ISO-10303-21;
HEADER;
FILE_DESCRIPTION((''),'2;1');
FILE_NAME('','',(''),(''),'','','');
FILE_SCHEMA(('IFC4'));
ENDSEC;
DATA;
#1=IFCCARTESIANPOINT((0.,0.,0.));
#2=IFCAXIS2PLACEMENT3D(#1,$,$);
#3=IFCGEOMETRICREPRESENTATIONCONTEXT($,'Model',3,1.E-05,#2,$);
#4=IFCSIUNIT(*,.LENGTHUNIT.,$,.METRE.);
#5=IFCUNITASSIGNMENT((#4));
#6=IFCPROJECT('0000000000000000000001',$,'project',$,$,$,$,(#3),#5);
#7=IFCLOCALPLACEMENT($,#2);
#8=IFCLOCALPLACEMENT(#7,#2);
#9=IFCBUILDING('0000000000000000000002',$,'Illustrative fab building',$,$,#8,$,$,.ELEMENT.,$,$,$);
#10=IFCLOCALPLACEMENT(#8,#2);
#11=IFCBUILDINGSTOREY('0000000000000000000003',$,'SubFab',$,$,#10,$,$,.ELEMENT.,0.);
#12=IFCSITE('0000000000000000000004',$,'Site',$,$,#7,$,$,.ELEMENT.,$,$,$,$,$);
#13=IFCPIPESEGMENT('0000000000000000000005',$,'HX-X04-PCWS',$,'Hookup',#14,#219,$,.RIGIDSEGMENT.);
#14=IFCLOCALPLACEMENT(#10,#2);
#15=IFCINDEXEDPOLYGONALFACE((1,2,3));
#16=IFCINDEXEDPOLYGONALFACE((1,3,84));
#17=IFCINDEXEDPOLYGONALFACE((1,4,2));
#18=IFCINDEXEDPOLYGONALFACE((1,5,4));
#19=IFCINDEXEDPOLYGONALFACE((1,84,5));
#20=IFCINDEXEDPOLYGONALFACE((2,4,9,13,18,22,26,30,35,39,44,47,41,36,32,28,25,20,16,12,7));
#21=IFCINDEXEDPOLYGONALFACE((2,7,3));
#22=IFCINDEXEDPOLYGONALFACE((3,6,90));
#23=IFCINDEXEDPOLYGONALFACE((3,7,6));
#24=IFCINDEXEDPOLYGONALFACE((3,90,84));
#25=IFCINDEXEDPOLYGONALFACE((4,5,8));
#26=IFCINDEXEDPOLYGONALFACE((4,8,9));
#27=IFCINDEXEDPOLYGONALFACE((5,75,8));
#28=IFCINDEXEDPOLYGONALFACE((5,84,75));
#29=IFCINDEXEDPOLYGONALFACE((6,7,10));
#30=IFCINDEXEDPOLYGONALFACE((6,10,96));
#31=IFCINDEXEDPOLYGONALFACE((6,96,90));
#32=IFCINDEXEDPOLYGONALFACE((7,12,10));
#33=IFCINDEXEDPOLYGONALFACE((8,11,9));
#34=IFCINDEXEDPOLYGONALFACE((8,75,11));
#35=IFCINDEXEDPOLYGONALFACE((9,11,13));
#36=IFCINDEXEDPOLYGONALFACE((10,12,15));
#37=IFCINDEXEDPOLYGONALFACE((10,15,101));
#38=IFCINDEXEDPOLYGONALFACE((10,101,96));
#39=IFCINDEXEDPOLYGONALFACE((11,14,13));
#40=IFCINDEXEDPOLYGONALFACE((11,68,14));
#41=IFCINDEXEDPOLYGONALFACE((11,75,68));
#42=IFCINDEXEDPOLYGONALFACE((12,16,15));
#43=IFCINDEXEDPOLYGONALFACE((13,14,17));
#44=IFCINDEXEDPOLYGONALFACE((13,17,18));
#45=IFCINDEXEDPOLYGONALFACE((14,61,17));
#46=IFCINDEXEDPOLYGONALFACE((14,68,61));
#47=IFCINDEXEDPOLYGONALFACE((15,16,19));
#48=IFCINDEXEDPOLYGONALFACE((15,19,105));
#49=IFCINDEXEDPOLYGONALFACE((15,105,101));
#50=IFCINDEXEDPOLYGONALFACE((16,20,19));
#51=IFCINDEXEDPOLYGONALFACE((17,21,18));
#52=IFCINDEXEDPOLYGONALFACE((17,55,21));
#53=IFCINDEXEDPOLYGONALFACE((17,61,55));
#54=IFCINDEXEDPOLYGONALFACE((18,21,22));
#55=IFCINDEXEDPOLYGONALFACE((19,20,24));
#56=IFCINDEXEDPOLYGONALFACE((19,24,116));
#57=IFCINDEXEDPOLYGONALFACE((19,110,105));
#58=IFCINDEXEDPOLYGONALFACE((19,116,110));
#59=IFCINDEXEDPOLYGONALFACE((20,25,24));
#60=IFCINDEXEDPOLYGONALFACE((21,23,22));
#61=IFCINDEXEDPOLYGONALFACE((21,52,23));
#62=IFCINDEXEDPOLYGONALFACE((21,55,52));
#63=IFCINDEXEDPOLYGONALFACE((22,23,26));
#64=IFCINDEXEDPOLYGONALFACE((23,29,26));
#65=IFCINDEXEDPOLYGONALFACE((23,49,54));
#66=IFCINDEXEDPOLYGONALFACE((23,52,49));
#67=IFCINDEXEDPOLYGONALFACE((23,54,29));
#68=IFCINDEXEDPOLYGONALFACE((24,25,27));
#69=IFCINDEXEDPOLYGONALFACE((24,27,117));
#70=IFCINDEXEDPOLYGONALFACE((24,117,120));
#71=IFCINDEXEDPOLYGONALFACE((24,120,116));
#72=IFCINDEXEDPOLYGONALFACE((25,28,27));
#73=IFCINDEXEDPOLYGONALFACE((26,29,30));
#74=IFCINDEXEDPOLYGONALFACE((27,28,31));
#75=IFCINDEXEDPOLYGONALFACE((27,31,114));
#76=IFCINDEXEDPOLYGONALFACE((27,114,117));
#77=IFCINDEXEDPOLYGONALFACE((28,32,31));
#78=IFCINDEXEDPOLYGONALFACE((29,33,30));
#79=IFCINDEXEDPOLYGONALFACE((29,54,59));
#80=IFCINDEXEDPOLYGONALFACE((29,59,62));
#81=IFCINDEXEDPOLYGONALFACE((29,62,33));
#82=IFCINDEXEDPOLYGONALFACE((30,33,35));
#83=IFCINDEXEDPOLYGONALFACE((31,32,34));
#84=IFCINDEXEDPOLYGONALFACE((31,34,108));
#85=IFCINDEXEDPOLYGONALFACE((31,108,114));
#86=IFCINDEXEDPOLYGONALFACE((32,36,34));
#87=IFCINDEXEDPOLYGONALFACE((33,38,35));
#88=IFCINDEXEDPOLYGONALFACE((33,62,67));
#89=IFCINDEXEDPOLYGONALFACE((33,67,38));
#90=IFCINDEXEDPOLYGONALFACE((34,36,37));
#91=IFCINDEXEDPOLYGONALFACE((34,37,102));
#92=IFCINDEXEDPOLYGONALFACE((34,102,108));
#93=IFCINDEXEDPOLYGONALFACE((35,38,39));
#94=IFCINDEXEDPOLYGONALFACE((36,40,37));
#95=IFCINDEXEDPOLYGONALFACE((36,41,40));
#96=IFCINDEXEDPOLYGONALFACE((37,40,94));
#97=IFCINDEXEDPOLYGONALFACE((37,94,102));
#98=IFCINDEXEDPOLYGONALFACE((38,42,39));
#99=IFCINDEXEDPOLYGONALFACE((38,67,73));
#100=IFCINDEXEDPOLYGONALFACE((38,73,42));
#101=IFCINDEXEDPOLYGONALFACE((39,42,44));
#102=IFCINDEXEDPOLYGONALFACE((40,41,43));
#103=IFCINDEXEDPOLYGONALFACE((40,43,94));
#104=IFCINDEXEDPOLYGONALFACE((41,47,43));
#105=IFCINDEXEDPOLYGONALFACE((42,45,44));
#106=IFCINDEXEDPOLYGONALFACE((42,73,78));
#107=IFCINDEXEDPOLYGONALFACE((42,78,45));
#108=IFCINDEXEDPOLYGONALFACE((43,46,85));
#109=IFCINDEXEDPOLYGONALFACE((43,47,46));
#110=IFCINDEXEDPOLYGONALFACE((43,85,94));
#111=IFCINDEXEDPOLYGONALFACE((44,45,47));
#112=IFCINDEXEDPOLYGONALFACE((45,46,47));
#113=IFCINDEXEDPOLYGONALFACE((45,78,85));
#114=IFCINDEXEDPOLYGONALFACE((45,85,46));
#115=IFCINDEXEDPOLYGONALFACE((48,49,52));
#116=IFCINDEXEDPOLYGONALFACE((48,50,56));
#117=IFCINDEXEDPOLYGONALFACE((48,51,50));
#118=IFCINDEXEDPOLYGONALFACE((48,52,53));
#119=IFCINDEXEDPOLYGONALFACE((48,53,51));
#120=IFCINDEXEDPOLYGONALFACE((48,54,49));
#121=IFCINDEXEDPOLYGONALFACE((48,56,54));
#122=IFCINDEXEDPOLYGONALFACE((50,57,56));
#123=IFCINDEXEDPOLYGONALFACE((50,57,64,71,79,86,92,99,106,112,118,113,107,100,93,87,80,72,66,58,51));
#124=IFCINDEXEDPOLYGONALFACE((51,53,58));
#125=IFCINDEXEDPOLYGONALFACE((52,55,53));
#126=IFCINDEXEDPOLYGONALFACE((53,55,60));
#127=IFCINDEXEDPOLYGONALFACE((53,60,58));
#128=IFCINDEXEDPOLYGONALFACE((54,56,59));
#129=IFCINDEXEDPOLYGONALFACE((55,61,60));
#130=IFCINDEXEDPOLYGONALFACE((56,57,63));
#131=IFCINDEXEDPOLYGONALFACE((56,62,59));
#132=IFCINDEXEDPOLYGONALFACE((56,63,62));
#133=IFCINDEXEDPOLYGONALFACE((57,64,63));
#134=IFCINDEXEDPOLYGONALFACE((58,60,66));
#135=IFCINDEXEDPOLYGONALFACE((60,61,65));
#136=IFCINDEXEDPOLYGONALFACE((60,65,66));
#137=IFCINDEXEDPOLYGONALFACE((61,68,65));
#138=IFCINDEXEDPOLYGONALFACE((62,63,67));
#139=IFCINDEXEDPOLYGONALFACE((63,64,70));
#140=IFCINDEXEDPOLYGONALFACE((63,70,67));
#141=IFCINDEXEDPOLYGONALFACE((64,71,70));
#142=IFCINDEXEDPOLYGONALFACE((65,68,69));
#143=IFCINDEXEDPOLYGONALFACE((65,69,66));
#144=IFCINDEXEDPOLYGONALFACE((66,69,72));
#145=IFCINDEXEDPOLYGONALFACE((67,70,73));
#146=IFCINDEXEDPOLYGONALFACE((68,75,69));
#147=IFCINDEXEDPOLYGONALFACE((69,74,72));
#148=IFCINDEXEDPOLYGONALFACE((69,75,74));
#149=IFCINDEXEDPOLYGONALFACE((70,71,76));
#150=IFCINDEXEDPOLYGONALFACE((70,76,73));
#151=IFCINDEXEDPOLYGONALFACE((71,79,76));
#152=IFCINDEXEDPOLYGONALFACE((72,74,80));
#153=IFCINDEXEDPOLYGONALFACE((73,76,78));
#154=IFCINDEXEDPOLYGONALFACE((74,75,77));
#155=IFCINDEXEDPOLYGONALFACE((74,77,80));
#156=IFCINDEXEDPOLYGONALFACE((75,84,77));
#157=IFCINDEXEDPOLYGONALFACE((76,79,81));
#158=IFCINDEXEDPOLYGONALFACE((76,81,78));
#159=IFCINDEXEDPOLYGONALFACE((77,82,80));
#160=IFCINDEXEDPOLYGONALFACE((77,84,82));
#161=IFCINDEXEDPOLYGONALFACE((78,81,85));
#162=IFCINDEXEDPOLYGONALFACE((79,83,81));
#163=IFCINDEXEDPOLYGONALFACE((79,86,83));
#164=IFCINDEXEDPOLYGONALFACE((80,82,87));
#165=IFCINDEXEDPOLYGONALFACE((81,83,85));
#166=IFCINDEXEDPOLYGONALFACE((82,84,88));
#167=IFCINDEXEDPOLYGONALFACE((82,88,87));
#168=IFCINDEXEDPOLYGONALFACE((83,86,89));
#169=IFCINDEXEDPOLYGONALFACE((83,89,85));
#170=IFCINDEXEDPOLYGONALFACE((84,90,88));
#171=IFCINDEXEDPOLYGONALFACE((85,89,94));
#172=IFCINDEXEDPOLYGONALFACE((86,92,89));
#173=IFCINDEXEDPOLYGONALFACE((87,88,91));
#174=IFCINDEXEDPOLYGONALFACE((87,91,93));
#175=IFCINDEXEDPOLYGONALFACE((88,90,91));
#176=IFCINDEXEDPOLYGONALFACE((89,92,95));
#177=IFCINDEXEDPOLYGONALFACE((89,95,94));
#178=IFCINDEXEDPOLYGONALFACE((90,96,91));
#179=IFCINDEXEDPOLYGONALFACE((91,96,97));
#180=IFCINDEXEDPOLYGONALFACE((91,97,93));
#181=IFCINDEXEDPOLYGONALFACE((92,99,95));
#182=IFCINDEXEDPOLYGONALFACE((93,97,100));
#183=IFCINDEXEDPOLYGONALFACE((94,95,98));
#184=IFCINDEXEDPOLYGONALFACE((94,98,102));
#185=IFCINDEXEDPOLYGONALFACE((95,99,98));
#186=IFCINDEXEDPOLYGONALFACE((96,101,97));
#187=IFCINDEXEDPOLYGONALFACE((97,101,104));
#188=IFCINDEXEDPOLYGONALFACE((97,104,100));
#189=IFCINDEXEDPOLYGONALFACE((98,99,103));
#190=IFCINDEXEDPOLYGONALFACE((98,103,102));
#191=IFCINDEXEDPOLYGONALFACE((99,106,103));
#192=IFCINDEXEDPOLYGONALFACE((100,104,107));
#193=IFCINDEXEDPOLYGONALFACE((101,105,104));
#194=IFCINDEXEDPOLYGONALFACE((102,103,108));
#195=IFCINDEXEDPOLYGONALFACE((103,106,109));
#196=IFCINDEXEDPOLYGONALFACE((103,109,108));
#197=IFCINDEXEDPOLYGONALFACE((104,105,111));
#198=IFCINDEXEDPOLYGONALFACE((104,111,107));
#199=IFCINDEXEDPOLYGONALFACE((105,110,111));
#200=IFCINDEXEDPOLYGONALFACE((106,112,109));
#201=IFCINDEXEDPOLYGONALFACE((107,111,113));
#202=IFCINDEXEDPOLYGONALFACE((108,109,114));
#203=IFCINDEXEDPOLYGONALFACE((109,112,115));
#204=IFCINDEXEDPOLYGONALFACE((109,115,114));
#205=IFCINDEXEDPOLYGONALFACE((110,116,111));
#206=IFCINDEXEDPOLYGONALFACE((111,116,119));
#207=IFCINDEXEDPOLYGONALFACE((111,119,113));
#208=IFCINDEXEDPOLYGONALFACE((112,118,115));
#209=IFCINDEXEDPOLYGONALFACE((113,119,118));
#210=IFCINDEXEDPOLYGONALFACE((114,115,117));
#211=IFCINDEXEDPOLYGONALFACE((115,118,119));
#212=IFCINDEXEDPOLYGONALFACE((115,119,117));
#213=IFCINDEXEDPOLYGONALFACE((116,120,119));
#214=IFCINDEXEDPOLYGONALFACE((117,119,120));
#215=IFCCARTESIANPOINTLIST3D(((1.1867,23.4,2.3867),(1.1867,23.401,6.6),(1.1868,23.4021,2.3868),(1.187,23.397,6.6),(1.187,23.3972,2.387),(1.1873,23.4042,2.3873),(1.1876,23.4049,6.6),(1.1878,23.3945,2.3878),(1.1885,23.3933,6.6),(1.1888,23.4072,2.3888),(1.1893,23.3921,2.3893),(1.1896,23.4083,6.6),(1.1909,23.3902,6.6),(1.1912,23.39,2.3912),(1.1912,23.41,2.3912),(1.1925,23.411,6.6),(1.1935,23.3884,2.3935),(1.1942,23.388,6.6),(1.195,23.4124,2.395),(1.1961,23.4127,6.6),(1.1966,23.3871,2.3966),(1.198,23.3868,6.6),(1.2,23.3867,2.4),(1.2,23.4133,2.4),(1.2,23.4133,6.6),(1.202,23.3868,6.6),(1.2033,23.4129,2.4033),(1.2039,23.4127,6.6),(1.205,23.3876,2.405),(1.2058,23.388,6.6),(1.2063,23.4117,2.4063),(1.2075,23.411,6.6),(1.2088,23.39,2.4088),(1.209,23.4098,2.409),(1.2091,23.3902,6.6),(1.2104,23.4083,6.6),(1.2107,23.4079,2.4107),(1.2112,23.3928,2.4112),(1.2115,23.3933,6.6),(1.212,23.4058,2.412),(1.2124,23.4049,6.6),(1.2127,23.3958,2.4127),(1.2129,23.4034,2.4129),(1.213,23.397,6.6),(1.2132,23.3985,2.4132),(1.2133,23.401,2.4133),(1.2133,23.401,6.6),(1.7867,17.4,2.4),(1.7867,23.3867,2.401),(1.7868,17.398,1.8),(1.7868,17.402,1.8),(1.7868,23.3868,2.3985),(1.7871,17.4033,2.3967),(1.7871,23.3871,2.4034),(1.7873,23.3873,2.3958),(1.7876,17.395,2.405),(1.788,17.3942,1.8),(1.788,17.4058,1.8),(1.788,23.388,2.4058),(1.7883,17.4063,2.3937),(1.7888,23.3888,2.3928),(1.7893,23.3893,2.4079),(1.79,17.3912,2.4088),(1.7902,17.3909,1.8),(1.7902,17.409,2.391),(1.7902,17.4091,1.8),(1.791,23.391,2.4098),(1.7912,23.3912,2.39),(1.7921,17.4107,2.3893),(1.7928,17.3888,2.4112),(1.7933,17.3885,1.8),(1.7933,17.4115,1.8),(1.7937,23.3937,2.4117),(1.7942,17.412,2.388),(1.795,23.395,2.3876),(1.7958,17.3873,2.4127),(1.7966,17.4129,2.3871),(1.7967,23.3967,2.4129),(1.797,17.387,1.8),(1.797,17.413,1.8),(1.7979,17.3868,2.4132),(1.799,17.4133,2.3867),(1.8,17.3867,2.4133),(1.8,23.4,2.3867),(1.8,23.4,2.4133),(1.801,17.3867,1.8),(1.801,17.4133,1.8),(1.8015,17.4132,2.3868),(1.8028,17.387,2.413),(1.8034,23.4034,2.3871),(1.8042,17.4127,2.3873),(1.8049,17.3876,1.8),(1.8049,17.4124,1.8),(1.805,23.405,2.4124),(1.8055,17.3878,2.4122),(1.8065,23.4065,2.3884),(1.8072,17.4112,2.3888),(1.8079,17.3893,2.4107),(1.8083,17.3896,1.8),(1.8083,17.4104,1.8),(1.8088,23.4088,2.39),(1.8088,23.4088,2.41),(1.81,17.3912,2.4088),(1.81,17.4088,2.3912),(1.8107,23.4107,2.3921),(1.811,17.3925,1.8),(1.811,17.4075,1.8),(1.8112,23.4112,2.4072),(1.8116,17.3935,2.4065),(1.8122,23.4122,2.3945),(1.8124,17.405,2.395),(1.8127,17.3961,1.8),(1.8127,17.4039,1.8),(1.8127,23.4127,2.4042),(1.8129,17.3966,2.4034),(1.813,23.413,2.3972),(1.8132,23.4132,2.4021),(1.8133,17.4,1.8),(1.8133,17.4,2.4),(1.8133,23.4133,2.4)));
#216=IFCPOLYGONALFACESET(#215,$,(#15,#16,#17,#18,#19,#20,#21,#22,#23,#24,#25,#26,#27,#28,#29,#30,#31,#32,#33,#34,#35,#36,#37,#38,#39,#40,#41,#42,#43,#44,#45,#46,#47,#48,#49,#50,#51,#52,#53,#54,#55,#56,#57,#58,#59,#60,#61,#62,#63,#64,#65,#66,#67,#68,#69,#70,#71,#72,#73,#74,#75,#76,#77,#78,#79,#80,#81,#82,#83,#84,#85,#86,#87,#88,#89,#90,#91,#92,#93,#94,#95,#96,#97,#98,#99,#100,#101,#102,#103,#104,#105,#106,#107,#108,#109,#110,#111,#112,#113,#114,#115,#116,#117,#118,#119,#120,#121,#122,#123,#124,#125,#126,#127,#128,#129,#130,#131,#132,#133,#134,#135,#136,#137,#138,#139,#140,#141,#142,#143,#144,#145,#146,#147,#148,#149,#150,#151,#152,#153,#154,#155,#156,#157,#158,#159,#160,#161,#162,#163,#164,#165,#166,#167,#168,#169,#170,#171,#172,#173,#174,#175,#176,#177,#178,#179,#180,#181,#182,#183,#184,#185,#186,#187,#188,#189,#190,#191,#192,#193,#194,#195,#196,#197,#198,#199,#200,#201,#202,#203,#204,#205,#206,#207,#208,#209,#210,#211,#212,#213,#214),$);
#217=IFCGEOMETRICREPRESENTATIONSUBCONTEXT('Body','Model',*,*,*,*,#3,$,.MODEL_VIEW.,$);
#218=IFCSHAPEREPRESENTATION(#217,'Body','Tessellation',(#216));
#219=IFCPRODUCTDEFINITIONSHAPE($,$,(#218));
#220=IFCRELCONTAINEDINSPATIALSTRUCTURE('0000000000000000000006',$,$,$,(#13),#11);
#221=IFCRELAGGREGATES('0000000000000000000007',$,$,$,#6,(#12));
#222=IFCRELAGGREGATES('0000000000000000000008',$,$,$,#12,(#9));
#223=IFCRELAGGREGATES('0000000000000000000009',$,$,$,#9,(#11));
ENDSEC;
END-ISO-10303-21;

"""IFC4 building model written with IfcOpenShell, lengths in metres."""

from ifc_helpers import new_model, entity, si_unit, origin, place, context, subcontext, project, spatial, element, save


model = new_model("IFC4")

# Units and contexts
model_context = context("Model", 3, precision=1e-05, world=origin())
body_context = subcontext(model_context, "Body", "Model", "MODEL_VIEW")
ifc_project = project(units=[si_unit("LENGTHUNIT", "METRE")], contexts=[model_context])

# Site, building, storey
site_placement = place(None, origin())
site = spatial("IfcSite", under=ifc_project, at=site_placement, Name="Site", CompositionType="ELEMENT")
building_placement = place(site_placement, origin())
building = spatial("IfcBuilding", under=site, at=building_placement, Name="Illustrative fab building", CompositionType="ELEMENT")
storey_placement = place(building_placement, origin())
storey = spatial("IfcBuildingStorey", under=building, at=storey_placement, Name="SubFab", CompositionType="ELEMENT", Elevation=0.0)

# Pipe segment
pipe_segment_1_placement = place(storey_placement, origin())
element("IfcPipeSegment", 1, at=pipe_segment_1_placement, inside=storey, Name="HX-X04-PCWS", ObjectType="Hookup", PredefinedType="RIGIDSEGMENT", context=body_context, shape_type="AdvancedSweptSolid", body=[
    entity("IfcSweptDiskSolid", entity("IfcPolyline", [entity("IfcCartesianPoint", [1.8, 17.4, 1.8]), entity("IfcCartesianPoint", [1.8, 17.4, 2.4]), entity("IfcCartesianPoint", [1.8, 23.4, 2.4]), entity("IfcCartesianPoint", [1.2, 23.4, 2.4]), entity("IfcCartesianPoint", [1.2, 23.4, 6.6])]), 0.0133),
])

save(model, "model.ifc")
